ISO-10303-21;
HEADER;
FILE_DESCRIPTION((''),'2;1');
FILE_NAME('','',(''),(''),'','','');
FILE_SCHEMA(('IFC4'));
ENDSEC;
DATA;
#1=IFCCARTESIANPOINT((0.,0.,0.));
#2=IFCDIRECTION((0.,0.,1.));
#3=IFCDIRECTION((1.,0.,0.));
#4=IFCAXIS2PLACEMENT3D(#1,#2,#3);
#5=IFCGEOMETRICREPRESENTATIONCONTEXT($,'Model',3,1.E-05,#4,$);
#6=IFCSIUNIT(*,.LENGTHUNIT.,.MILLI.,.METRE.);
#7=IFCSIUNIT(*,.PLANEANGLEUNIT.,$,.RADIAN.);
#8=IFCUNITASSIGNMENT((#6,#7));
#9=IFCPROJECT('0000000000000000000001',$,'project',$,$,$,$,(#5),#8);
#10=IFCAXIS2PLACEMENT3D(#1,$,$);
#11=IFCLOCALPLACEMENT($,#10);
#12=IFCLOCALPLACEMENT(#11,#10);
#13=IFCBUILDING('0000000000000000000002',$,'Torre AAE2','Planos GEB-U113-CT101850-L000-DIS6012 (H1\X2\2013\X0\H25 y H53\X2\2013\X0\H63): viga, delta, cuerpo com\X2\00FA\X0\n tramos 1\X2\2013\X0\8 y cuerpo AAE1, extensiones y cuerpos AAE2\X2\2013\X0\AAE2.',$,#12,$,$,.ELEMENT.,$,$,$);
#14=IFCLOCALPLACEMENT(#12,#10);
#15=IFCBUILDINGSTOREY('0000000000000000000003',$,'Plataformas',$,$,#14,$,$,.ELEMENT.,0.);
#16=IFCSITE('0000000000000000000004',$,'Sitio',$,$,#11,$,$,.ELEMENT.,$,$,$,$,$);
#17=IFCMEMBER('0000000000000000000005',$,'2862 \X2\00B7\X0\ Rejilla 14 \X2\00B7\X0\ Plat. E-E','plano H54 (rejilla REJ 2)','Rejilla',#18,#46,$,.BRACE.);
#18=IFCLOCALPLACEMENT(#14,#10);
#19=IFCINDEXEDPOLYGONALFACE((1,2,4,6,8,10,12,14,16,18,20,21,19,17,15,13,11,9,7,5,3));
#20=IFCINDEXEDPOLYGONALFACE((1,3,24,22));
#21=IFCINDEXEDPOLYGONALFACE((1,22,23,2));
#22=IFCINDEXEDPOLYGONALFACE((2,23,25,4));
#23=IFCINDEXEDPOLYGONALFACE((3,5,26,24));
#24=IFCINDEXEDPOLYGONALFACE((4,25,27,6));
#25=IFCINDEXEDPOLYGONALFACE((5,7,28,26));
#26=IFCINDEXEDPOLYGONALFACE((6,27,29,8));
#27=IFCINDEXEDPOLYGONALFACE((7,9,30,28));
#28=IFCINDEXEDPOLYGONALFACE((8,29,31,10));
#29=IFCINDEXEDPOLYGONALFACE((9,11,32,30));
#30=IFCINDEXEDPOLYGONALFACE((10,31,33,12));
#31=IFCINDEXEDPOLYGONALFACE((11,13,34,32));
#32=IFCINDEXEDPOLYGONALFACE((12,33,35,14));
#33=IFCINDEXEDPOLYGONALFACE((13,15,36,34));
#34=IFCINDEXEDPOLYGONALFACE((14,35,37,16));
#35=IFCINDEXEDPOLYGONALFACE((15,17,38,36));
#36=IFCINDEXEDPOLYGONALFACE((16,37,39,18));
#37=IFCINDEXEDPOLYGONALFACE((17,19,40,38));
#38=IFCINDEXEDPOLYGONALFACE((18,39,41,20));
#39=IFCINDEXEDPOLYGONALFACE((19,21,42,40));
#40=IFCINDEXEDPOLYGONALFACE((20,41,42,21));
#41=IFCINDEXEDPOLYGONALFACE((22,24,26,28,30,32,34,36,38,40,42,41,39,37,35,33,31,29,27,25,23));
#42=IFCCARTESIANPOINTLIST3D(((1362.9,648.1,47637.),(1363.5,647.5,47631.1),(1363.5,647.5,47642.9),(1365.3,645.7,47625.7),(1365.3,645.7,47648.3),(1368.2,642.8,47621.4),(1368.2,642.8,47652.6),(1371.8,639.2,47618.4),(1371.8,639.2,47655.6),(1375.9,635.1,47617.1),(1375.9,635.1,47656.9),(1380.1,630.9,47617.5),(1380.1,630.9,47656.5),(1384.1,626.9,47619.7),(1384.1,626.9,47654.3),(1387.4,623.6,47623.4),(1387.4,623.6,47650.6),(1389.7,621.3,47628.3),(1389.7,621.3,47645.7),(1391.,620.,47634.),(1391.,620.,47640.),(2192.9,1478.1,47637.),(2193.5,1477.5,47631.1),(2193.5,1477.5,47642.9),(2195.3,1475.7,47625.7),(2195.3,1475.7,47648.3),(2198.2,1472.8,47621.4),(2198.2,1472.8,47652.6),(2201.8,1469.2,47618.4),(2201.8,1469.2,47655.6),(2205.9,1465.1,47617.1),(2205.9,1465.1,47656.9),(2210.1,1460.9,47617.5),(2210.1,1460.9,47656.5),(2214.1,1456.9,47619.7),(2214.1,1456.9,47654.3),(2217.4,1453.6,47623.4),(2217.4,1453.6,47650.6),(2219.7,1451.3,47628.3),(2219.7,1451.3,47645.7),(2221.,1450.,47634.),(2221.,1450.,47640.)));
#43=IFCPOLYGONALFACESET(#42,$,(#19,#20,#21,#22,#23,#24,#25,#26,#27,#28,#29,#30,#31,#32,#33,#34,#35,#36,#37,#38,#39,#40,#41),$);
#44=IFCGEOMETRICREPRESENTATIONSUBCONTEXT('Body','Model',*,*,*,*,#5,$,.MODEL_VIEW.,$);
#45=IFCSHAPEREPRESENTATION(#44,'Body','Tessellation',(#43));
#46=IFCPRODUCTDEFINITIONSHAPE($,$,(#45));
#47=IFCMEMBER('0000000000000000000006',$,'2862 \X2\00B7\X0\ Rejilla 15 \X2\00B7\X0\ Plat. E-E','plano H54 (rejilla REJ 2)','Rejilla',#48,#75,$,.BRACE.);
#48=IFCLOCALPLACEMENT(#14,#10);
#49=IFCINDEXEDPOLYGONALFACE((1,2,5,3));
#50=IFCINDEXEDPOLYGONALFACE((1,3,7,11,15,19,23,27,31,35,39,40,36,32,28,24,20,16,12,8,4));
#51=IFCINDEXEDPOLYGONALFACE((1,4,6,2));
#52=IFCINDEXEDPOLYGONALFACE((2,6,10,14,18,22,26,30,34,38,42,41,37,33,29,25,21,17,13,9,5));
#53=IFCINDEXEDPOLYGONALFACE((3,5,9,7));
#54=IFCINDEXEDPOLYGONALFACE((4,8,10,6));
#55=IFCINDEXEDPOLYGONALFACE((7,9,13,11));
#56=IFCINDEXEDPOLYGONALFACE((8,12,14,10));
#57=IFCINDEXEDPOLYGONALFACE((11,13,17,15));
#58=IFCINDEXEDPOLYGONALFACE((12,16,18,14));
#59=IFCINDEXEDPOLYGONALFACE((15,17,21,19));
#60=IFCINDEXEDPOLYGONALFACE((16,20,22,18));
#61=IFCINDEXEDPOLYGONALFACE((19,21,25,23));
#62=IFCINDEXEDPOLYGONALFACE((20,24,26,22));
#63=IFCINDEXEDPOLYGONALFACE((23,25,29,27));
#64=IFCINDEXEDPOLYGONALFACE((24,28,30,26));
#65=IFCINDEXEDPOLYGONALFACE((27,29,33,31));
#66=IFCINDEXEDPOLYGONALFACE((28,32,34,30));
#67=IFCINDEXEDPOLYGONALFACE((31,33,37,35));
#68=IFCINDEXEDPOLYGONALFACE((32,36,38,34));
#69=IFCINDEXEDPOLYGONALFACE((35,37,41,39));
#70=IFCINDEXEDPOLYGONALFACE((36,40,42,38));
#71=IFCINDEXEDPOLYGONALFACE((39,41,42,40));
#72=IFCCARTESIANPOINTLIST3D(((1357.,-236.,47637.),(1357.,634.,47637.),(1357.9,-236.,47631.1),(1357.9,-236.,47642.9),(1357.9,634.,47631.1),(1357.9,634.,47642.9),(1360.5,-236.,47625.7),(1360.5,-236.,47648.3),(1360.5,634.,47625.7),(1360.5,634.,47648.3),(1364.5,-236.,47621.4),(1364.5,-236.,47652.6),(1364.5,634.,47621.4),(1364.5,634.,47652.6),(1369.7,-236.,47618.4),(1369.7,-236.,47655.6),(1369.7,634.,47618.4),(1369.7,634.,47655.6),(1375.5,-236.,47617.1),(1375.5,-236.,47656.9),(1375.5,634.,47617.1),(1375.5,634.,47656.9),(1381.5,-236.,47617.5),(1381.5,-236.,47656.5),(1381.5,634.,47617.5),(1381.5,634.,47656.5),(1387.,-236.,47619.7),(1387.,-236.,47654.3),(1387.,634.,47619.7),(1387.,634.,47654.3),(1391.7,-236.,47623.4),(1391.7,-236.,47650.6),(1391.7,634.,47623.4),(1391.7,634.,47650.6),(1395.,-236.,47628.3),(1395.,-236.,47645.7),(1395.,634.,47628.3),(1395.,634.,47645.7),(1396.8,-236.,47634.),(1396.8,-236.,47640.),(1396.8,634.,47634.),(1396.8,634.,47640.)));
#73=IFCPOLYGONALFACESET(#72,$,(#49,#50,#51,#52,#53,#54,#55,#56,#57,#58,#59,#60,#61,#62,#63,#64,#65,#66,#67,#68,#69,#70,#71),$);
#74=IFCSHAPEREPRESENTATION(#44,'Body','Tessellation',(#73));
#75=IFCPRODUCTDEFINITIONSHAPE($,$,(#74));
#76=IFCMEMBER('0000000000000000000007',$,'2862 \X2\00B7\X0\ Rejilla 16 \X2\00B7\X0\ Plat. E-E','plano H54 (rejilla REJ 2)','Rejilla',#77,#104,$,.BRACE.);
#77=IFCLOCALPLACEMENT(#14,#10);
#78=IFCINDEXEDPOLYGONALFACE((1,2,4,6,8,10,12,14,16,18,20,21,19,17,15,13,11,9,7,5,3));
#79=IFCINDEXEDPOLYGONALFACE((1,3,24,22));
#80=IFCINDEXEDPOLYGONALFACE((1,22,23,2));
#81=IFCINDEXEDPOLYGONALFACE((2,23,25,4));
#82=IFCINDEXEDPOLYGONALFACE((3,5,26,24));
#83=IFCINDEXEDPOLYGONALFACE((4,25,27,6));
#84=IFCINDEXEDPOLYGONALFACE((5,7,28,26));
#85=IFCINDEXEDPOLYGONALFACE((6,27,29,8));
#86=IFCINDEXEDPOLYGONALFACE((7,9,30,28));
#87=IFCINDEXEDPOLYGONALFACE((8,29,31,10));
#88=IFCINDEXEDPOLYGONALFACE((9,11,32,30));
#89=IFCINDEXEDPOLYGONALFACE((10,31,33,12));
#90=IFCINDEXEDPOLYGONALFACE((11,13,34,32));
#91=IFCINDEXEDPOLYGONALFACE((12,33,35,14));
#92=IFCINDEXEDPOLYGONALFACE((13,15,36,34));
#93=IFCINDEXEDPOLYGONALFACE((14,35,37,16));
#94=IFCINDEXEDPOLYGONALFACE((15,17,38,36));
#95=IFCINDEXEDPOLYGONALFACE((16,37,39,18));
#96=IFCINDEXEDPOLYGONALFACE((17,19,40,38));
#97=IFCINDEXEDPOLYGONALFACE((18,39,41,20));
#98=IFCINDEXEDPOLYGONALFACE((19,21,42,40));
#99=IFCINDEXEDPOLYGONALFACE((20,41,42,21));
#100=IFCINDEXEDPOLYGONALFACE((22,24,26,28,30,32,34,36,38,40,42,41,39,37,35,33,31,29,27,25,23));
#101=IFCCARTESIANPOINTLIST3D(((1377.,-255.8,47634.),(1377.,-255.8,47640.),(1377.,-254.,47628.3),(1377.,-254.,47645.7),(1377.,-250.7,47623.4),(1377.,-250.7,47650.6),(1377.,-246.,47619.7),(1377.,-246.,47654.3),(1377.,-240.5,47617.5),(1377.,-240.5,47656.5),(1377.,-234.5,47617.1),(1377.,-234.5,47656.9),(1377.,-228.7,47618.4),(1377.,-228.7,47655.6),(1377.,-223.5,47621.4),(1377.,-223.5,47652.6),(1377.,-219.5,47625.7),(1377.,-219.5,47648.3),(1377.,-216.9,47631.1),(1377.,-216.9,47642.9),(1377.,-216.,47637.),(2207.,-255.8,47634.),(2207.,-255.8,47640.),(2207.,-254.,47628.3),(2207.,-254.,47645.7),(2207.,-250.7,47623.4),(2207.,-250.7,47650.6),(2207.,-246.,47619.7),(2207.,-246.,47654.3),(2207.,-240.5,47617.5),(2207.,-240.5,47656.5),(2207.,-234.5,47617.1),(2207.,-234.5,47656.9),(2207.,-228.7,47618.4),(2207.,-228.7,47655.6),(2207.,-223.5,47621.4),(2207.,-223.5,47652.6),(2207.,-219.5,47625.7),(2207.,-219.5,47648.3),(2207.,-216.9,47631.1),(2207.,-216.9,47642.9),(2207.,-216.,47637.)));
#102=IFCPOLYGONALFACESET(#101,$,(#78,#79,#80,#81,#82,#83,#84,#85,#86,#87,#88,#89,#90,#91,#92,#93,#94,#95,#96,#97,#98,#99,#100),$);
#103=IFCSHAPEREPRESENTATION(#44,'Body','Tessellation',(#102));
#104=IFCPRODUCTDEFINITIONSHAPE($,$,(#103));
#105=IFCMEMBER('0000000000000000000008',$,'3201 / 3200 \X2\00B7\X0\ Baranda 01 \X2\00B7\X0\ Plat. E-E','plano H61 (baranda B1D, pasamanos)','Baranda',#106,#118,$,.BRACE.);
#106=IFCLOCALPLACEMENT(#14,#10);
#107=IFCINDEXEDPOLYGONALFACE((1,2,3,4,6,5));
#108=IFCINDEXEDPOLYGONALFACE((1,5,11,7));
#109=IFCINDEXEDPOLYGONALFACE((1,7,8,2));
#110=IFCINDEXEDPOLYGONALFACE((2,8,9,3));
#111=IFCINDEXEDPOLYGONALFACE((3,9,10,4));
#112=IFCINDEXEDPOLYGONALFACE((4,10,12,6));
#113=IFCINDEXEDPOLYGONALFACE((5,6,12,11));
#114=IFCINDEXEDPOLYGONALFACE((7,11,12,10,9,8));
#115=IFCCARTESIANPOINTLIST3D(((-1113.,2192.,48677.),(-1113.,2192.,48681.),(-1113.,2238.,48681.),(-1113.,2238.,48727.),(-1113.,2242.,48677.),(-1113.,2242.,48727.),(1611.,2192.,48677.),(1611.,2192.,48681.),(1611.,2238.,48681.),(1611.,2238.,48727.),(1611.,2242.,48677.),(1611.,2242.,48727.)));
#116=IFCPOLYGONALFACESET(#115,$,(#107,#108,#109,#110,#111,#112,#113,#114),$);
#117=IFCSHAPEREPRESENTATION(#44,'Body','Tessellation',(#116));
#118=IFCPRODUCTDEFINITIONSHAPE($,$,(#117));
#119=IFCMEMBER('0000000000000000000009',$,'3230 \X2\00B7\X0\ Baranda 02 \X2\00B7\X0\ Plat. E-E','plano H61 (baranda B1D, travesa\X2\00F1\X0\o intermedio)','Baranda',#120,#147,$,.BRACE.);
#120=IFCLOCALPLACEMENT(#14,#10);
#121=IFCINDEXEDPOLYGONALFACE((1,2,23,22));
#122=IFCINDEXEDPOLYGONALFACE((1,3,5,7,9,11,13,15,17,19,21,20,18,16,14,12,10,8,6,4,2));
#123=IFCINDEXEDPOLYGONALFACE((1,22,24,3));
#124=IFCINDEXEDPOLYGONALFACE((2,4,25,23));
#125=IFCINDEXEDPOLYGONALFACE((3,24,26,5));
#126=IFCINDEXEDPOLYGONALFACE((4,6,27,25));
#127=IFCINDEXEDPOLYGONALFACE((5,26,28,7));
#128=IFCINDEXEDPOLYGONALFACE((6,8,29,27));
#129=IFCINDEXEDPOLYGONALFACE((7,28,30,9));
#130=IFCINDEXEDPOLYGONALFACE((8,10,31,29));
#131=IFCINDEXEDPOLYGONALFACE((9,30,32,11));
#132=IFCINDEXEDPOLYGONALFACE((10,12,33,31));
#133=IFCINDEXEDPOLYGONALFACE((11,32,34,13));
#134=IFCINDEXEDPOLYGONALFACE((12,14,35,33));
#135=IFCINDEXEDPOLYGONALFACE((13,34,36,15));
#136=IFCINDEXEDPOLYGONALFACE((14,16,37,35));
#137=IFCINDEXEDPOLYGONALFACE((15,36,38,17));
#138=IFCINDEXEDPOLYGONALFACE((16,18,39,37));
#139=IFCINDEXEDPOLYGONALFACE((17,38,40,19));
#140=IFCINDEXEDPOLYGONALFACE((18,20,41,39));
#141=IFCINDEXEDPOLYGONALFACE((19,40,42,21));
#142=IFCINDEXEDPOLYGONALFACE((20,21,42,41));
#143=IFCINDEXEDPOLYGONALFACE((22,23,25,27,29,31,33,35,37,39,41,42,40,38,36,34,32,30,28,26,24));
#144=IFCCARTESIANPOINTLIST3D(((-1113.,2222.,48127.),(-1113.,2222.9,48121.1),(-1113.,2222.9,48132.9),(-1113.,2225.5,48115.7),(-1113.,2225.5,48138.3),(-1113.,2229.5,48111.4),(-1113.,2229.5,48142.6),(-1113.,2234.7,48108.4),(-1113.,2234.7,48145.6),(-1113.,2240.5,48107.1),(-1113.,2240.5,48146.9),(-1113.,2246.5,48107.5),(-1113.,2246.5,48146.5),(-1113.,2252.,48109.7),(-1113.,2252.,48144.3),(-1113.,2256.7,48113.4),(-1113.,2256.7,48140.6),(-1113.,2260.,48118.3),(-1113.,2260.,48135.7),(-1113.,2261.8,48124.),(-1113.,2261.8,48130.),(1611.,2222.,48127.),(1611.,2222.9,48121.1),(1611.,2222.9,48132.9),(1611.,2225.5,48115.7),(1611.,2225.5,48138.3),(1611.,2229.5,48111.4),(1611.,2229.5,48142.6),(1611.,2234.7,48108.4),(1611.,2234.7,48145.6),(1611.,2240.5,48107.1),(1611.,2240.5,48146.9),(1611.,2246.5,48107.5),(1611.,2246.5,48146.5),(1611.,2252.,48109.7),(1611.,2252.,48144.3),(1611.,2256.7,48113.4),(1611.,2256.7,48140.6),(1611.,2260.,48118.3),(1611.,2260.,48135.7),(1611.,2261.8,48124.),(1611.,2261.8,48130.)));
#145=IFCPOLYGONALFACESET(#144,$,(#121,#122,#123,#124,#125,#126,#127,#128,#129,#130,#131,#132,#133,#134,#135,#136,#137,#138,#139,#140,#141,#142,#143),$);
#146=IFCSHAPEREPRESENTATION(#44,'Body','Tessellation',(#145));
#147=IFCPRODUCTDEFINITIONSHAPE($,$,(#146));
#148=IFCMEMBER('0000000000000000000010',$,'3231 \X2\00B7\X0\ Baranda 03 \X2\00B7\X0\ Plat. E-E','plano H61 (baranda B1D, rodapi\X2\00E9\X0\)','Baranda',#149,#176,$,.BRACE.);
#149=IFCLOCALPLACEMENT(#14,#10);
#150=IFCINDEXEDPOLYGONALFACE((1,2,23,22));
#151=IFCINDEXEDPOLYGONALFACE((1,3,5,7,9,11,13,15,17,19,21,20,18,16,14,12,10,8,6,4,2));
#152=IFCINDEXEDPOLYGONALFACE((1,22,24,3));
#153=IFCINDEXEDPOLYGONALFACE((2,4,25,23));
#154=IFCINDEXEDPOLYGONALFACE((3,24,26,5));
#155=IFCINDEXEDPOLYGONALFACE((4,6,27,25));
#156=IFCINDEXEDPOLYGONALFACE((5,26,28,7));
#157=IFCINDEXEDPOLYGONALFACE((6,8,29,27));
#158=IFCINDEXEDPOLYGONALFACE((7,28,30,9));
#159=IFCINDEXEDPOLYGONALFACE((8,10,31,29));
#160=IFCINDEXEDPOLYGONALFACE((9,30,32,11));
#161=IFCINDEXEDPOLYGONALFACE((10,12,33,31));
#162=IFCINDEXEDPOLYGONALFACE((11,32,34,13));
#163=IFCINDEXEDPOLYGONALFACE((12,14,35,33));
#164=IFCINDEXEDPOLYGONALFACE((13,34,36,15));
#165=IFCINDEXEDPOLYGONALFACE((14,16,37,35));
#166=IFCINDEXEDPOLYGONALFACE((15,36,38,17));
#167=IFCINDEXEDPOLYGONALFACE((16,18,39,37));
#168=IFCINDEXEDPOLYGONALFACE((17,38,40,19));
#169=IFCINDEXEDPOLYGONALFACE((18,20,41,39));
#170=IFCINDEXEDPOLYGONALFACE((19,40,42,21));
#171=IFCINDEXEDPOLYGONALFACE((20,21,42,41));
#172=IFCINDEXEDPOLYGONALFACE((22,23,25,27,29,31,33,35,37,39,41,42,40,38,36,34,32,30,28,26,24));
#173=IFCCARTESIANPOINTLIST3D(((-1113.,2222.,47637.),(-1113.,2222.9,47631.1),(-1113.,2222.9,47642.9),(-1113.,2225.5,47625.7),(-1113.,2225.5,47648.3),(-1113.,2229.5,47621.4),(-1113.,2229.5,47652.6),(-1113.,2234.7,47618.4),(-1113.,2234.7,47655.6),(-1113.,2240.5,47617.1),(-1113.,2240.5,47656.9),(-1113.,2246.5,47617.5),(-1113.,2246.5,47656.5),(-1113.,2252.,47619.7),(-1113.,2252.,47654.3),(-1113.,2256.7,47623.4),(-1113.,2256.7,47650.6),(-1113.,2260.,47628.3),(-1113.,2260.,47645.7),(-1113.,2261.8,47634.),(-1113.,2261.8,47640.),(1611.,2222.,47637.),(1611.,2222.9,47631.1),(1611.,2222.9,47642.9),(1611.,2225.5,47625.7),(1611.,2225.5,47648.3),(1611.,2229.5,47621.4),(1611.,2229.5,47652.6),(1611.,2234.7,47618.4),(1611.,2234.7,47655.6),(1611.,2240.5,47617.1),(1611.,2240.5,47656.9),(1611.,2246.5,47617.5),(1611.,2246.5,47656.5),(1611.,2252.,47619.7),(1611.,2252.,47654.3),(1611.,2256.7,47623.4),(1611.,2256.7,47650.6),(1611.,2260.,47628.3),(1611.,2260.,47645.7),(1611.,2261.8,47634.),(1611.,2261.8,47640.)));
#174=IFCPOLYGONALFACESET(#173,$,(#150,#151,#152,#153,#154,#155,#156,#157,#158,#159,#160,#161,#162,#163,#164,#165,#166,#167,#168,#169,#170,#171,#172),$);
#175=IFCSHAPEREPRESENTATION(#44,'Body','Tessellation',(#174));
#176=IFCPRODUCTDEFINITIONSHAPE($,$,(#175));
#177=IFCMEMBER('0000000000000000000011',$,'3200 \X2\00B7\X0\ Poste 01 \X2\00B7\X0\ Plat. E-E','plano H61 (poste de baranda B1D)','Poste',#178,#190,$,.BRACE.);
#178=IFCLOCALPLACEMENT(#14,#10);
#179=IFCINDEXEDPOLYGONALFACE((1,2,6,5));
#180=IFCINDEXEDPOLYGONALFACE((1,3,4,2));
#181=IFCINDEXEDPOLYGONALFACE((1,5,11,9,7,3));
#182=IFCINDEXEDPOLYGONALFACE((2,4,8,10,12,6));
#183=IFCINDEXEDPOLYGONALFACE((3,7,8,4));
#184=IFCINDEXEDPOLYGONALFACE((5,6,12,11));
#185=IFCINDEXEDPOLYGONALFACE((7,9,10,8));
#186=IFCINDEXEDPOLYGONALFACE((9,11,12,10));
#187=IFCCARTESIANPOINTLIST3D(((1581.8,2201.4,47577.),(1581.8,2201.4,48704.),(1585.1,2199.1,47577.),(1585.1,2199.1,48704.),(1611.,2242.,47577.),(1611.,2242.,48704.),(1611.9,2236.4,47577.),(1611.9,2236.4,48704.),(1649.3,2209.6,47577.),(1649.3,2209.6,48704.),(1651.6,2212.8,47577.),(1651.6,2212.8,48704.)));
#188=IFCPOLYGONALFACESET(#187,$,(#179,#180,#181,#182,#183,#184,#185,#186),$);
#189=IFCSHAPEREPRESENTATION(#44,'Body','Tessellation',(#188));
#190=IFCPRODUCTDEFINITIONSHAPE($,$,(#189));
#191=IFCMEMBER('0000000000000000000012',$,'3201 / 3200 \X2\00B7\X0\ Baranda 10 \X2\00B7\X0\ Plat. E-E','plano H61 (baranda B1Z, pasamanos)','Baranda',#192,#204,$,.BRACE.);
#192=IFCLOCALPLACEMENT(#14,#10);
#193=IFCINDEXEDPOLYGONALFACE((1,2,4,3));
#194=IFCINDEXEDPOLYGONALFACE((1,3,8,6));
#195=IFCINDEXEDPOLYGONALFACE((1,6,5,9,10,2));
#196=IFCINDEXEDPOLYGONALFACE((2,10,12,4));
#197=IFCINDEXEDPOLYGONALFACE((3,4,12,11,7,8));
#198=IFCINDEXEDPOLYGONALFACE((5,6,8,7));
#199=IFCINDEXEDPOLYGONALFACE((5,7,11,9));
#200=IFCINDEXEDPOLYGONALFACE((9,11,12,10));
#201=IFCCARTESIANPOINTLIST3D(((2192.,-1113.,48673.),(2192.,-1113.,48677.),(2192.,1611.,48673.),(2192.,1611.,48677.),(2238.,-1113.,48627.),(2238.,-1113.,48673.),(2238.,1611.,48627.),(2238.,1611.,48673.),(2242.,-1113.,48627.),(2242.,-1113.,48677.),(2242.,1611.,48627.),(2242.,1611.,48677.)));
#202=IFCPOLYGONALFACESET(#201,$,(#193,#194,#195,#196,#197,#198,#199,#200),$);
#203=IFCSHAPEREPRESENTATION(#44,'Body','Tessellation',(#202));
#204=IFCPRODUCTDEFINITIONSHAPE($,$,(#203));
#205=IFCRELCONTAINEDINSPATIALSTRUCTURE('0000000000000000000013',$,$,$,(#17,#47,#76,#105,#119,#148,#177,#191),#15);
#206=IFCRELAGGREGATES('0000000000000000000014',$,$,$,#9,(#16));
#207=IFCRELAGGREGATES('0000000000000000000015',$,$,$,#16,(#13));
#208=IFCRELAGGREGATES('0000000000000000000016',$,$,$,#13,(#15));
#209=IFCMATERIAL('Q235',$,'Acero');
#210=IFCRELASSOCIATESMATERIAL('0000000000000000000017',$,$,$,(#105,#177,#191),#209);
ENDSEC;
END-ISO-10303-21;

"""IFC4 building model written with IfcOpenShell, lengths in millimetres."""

from ifc_helpers import new_model, si_unit, frame, frame_2d, origin, origin_with_axes, place, context, subcontext, project, spatial, circle, l_section, extrude, material, element, save


model = new_model("IFC4")

# Units and contexts
model_context = context("Model", 3, precision=1e-05, world=origin_with_axes())
body_context = subcontext(model_context, "Body", "Model", "MODEL_VIEW")
ifc_project = project(units=[si_unit("LENGTHUNIT", "METRE", prefix="MILLI"), si_unit("PLANEANGLEUNIT", "RADIAN")], contexts=[model_context])

# Site, building, storey
site_placement = place(None, origin())
site = spatial("IfcSite", under=ifc_project, at=site_placement, Name="Sitio", CompositionType="ELEMENT")
building_placement = place(site_placement, origin())
building = spatial("IfcBuilding", under=site, at=building_placement, Name="Torre AAE2", Description="Planos GEB-U113-CT101850-L000-DIS6012 (H1–H25 y H53–H63): viga, delta, cuerpo común tramos 1–8 y cuerpo AAE1, extensiones y cuerpos AAE2–AAE2.", CompositionType="ELEMENT")
storey_placement = place(building_placement, origin())
storey = spatial("IfcBuildingStorey", under=building, at=storey_placement, Name="Plataformas", CompositionType="ELEMENT", Elevation=0.0)

# Members
member_1_placement = place(storey_placement, frame((2207.0, 1464.0, 47637.0), z_axis=(-0.707107, -0.707107, 0.0), x_axis=(-0.707107, 0.707107, 0.0)))
element("IfcMember", 1, at=member_1_placement, inside=storey, Name="2862 · Rejilla 14 · Plat. E-E", Description="plano H54 (rejilla REJ 2)", ObjectType="Rejilla", PredefinedType="BRACE", context=body_context, shape_type="SweptSolid", body=[
    extrude(circle(Radius=20.0), None, (0.0, 0.0, 1.0), 1173.8),
])
member_2_placement = place(storey_placement, frame((1377.0, 634.0, 47637.0), z_axis=(0.0, -1.0, 0.0), x_axis=(-1.0, 0.0, 0.0)))
element("IfcMember", 2, at=member_2_placement, inside=storey, Name="2862 · Rejilla 15 · Plat. E-E", Description="plano H54 (rejilla REJ 2)", ObjectType="Rejilla", PredefinedType="BRACE", context=body_context, shape_type="SweptSolid", body=[
    extrude(circle(Radius=20.0), None, (0.0, 0.0, 1.0), 870.0),
])
member_3_placement = place(storey_placement, frame((1377.0, -236.0, 47637.0), z_axis=(1.0, 0.0, 0.0), x_axis=(0.0, 1.0, 0.0)))
element("IfcMember", 3, at=member_3_placement, inside=storey, Name="2862 · Rejilla 16 · Plat. E-E", Description="plano H54 (rejilla REJ 2)", ObjectType="Rejilla", PredefinedType="BRACE", context=body_context, shape_type="SweptSolid", body=[
    extrude(circle(Radius=20.0), None, (0.0, 0.0, 1.0), 830.0),
])
ifc_material = material(Name="Q235", Category="Acero")
member_4_placement = place(storey_placement, frame((1611.0, 2242.0, 48677.0), z_axis=(-1.0, 0.0, 0.0), x_axis=(0.0, -1.0, 0.0)))
element("IfcMember", 4, at=member_4_placement, inside=storey, material=ifc_material, Name="3201 / 3200 · Baranda 01 · Plat. E-E", Description="plano H61 (baranda B1D, pasamanos)", ObjectType="Baranda", PredefinedType="BRACE", context=body_context, shape_type="SweptSolid", body=[
    extrude(l_section(Depth=50.0, Width=50.0, Thickness=4.0, at=frame_2d((25.0, 25.0))), None, (0.0, 0.0, 1.0), 2724.0),
])
for number, where, z_axis, x_axis, name, description in (
    (5, (1611.0, 2242.0, 48127.0), (-1.0, 0.0, 0.0), (0.0, -1.0, 0.0), "3230 · Baranda 02 · Plat. E-E", "plano H61 (baranda B1D, travesaño intermedio)"),
    (6, (1611.0, 2242.0, 47637.0), (-1.0, 0.0, 0.0), (0.0, -1.0, 0.0), "3231 · Baranda 03 · Plat. E-E", "plano H61 (baranda B1D, rodapié)"),
):
    element("IfcMember", number, at=place(storey_placement, frame(where, z_axis=z_axis, x_axis=x_axis)), inside=storey, Name=name, Description=description, ObjectType="Baranda", PredefinedType="BRACE", context=body_context, shape_type="SweptSolid", body=[
        extrude(circle(Radius=20.0), None, (0.0, 0.0, 1.0), 2724.0),
    ])
member_5_placement = place(storey_placement, frame((1611.0, 2242.0, 47577.0), z_axis=(0.0, 0.0, 1.0), x_axis=(-0.583532, -0.81209, 0.0)))
element("IfcMember", 7, at=member_5_placement, inside=storey, material=ifc_material, Name="3200 · Poste 01 · Plat. E-E", Description="plano H61 (poste de baranda B1D)", ObjectType="Poste", PredefinedType="BRACE", context=body_context, shape_type="SweptSolid", body=[
    extrude(l_section(Depth=50.0, Width=50.0, Thickness=4.0, at=frame_2d((25.0, 25.0))), None, (0.0, 0.0, 1.0), 1127.0),
])
member_6_placement = place(storey_placement, frame((2242.0, 1611.0, 48677.0), z_axis=(0.0, -1.0, 0.0), x_axis=(-1.0, 0.0, 0.0)))
element("IfcMember", 8, at=member_6_placement, inside=storey, material=ifc_material, Name="3201 / 3200 · Baranda 10 · Plat. E-E", Description="plano H61 (baranda B1Z, pasamanos)", ObjectType="Baranda", PredefinedType="BRACE", context=body_context, shape_type="SweptSolid", body=[
    extrude(l_section(Depth=50.0, Width=50.0, Thickness=4.0, at=frame_2d((25.0, 25.0))), None, (0.0, 0.0, 1.0), 2724.0),
])

save(model, "model.ifc")
